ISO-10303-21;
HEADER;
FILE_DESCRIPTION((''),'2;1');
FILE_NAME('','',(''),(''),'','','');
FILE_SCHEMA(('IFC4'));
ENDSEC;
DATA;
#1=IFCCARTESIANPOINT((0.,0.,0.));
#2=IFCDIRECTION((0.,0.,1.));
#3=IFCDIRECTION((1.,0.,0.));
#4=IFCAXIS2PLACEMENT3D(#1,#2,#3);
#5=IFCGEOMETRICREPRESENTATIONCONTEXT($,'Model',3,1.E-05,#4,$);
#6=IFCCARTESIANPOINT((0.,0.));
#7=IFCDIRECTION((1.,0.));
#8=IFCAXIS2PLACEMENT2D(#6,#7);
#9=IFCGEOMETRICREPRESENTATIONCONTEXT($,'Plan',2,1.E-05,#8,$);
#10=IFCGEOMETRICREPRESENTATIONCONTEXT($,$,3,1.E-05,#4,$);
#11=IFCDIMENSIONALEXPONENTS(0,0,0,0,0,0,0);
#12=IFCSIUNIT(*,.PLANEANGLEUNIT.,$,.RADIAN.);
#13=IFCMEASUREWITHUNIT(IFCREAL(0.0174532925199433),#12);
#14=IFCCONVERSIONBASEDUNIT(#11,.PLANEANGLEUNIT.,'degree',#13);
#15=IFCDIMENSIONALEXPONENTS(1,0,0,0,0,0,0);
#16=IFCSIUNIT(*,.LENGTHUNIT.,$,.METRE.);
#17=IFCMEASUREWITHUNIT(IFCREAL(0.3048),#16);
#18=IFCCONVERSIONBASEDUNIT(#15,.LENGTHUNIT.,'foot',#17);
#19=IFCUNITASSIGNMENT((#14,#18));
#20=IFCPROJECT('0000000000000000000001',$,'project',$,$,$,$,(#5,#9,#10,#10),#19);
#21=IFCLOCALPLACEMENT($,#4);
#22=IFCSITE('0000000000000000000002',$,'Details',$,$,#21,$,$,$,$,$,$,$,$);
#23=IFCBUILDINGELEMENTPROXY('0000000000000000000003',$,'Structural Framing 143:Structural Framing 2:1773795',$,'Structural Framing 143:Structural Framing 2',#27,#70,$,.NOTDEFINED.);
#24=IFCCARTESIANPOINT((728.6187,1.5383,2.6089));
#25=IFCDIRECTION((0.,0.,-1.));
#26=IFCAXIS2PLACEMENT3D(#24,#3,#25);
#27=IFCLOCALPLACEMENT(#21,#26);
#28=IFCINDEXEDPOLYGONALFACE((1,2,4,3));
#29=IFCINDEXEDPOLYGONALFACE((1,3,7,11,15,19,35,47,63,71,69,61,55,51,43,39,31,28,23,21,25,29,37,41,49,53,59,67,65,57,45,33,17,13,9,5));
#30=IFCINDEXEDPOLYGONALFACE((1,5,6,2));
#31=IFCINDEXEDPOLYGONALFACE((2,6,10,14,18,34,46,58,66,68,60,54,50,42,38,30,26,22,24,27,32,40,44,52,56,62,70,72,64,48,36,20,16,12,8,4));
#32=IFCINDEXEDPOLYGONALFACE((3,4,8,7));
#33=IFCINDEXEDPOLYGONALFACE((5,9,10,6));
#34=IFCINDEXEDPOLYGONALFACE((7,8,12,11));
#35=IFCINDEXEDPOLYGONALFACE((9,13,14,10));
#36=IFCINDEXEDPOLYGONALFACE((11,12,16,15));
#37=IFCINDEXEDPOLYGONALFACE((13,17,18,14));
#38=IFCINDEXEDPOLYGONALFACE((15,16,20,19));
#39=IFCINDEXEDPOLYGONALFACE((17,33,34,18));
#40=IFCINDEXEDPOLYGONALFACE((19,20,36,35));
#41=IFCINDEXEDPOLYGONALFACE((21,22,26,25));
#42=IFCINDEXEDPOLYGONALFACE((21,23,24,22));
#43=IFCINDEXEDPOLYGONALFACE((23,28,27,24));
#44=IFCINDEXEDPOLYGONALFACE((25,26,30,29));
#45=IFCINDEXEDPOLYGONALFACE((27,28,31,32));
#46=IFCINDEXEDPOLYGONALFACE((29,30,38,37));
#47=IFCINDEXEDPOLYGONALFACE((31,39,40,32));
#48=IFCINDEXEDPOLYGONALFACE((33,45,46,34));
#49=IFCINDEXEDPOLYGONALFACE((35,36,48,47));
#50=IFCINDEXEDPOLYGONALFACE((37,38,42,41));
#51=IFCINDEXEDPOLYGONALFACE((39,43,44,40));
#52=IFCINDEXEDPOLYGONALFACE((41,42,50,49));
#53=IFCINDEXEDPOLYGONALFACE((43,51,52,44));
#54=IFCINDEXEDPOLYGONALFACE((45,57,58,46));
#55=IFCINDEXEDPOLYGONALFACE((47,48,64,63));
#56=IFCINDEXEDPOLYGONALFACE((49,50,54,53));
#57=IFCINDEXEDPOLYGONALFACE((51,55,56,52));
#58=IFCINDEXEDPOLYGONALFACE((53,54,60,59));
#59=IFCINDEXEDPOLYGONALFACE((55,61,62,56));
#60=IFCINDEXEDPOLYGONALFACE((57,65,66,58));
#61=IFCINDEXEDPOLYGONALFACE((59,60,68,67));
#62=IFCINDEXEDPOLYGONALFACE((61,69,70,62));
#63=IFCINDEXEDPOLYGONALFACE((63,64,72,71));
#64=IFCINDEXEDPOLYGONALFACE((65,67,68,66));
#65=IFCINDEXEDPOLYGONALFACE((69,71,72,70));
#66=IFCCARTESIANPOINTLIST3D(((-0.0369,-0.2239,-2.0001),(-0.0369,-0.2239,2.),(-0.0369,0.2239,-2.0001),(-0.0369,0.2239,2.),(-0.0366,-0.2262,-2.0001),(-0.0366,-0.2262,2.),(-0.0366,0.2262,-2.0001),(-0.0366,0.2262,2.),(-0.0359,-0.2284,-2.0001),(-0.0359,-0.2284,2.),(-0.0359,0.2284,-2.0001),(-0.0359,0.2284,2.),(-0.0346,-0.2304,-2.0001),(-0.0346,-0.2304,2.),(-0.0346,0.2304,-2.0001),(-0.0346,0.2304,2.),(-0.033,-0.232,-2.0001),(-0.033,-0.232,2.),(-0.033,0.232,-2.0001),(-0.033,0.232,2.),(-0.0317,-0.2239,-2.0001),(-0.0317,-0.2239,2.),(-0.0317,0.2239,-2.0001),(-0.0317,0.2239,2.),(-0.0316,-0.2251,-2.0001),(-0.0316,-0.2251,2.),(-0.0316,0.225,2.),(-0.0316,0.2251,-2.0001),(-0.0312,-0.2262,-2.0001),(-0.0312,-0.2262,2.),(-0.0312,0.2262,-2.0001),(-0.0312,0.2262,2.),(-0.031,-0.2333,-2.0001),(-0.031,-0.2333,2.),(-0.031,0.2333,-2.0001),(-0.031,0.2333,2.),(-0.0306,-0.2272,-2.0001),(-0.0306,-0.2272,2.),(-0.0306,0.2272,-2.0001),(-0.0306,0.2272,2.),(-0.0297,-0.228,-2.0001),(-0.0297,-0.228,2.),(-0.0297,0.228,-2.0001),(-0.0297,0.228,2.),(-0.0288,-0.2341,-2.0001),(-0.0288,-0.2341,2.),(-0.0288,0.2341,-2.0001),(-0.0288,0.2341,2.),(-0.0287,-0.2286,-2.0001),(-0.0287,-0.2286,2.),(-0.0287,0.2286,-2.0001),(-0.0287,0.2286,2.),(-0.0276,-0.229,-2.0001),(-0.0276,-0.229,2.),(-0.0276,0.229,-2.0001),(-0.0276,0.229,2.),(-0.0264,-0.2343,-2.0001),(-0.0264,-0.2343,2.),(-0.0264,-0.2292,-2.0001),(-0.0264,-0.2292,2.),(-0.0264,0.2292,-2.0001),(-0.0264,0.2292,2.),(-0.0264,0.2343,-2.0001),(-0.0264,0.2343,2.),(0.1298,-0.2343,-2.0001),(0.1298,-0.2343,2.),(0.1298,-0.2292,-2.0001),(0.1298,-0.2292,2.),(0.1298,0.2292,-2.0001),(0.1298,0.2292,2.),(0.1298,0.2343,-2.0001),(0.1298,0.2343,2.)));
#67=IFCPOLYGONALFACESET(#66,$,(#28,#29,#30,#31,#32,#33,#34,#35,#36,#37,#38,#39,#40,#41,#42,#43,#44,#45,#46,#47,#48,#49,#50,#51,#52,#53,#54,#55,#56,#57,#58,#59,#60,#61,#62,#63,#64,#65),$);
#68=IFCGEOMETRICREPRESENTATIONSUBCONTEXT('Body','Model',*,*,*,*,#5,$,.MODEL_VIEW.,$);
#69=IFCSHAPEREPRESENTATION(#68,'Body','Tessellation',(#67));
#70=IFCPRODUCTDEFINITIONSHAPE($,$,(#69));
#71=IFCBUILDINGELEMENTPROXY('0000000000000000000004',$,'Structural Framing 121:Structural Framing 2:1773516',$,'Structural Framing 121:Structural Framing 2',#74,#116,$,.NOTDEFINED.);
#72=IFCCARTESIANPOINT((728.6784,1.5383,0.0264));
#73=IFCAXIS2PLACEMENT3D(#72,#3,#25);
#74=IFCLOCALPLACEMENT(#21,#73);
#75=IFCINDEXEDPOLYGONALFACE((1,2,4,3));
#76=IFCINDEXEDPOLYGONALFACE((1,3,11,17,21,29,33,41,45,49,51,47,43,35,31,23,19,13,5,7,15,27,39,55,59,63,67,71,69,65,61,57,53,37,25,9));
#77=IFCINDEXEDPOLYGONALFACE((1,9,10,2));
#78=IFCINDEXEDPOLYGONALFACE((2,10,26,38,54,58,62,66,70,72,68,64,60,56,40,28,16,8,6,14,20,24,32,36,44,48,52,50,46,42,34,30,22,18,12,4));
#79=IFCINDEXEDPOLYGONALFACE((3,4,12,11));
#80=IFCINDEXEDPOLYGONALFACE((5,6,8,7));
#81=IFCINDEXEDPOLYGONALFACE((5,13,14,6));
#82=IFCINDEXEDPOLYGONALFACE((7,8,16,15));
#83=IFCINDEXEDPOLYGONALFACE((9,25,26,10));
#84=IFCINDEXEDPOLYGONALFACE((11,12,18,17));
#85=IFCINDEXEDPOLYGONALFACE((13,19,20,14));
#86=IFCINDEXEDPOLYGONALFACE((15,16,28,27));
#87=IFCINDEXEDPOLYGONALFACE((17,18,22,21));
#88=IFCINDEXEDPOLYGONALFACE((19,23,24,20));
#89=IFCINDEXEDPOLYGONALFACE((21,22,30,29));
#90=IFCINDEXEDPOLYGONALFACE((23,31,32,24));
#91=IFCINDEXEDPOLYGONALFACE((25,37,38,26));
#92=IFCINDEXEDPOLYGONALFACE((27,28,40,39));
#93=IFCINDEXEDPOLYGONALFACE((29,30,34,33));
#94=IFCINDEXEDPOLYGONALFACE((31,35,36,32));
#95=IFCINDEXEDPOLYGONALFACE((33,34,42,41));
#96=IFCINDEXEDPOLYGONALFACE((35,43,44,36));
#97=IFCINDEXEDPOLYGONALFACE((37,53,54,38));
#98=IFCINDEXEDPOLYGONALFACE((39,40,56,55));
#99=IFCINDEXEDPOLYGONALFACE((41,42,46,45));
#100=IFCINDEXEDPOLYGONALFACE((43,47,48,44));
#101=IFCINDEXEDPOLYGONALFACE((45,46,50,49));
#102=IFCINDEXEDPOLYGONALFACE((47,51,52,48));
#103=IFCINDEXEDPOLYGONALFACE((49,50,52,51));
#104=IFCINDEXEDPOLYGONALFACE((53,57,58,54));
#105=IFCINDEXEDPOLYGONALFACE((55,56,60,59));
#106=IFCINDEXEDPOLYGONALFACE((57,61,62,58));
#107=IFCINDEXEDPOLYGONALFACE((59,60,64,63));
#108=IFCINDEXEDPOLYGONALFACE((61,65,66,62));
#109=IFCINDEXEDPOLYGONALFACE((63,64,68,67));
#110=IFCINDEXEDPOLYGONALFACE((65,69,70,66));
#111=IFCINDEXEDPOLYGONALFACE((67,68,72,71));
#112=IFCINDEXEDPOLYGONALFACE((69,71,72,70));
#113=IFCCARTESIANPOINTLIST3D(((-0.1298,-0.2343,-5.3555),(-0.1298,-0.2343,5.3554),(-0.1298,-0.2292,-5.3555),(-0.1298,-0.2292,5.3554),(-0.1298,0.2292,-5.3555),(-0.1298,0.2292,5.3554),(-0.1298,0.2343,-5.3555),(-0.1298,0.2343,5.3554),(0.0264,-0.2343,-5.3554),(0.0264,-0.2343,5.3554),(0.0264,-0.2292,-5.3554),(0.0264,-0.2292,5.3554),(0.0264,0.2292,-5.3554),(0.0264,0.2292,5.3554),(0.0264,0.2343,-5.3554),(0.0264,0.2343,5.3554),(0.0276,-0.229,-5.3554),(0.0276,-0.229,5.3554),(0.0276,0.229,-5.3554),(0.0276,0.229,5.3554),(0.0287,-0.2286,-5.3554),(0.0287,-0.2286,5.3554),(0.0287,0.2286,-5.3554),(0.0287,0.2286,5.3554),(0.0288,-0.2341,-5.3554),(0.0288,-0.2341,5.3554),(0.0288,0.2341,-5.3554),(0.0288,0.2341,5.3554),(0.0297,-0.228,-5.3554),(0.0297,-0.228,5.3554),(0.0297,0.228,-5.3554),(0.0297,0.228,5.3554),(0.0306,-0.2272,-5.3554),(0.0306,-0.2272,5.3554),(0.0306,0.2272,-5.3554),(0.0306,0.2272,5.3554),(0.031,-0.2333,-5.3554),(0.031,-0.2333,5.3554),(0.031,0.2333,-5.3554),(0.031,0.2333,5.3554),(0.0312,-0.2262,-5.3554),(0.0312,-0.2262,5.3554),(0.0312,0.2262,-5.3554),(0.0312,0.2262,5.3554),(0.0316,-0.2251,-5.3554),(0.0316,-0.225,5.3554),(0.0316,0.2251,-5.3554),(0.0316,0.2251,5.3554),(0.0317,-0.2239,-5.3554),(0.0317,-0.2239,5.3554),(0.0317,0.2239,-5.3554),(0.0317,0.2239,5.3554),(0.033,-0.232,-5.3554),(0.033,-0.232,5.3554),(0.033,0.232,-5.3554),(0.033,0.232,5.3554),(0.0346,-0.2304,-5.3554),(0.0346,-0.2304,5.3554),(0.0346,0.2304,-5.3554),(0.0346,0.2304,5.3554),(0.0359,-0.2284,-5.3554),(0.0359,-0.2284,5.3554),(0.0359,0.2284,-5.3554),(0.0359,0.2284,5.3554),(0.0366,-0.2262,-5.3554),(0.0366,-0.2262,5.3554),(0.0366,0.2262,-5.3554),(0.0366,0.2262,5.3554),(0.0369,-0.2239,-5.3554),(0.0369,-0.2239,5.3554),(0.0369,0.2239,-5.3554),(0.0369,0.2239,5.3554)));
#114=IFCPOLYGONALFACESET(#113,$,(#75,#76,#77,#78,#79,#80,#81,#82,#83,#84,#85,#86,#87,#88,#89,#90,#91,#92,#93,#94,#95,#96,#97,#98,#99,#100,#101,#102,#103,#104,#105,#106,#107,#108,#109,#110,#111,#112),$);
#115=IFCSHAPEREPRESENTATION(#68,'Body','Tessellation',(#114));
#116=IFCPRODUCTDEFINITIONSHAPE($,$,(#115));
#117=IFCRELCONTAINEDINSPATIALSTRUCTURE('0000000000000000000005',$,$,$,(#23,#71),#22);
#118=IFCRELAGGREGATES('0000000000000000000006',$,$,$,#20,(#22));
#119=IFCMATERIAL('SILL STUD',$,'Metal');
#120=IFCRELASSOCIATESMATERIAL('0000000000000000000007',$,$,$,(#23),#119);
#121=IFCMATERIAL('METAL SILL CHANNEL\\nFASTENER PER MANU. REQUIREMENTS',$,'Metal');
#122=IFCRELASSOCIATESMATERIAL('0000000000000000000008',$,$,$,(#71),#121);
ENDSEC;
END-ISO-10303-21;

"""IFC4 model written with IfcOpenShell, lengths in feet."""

from ifc_helpers import new_model, entity, si_unit, converted_unit, frame, origin_with_axes, origin_2d_with_axis, place, context, subcontext, project, spatial, polyline, outline, extrude, material, element, save


model = new_model("IFC4")

# Units and contexts
model_context = context("Model", 3, precision=1e-05, world=origin_with_axes())
plan_context = context("Plan", 2, precision=1e-05, world=origin_2d_with_axis())
context_of_model = context(None, 3, precision=1e-05, world=origin_with_axes())
body_context = subcontext(model_context, "Body", "Model", "MODEL_VIEW")
ifc_project = project(units=[converted_unit("PLANEANGLEUNIT", "degree", entity("IfcReal", 0.0174532925199433), si_unit("PLANEANGLEUNIT", "RADIAN"), dimensions=[0, 0, 0, 0, 0, 0, 0]), converted_unit("LENGTHUNIT", "foot", entity("IfcReal", 0.3048), si_unit("LENGTHUNIT", "METRE"), dimensions=[1, 0, 0, 0, 0, 0, 0])], contexts=[model_context, plan_context, context_of_model, context_of_model])

# Site
site_placement = place(None, origin_with_axes())
site = spatial("IfcSite", under=ifc_project, at=site_placement, Name="Details")

# Building element proxies
ifc_material_1 = material(Name="SILL STUD", Category="Metal")
proxy_1_placement = place(site_placement, frame((728.6187, 1.5383, 2.6089), z_axis=(1.0, 0.0, 0.0), x_axis=(0.0, 0.0, -1.0)))
element("IfcBuildingElementProxy", 1, at=proxy_1_placement, inside=site, material=ifc_material_1, Name="Structural Framing 143:Structural Framing 2:1773795", ObjectType="Structural Framing 143:Structural Framing 2", PredefinedType="NOTDEFINED", context=body_context, shape_type="SweptSolid", body=[
    extrude(outline(polyline([(0.2295, 0.0), (0.2295, -0.0012), (0.2199, -0.1571), (0.225, -0.1574), (0.2347, -0.0015), (0.2346, 0.0008), (0.2339, 0.0031), (0.2328, 0.0051), (0.2313, 0.0069), (0.2294, 0.0083), (0.2272, 0.0092), (0.2249, 0.0096), (-0.222, 0.0373), (-0.2243, 0.0372), (-0.2266, 0.0366), (-0.2286, 0.0354), (-0.2304, 0.0339), (-0.2317, 0.032), (-0.2327, 0.0298), (-0.2331, 0.0275), (-0.2427, -0.1284), (-0.2376, -0.1287), (-0.2279, 0.0272), (-0.2277, 0.0284), (-0.2273, 0.0295), (-0.2266, 0.0304), (-0.2257, 0.0312), (-0.2246, 0.0318), (-0.2235, 0.0321), (-0.2223, 0.0322), (0.2246, 0.0044), (0.2257, 0.0042), (0.2268, 0.0038), (0.2278, 0.0031), (0.2286, 0.0022), (0.2292, 0.0011), (0.2295, 0.0)])), frame((-0.0134, 0.0, -2.0001), z_axis=(0.000047, 0.0, -1.0), x_axis=(-0.061956, -0.998079, -0.000003)), (-0.000003, -0.000047, -1.0), 4.0),
])
ifc_material_2 = material(Name="METAL SILL CHANNEL\\nFASTENER PER MANU. REQUIREMENTS", Category="Metal")
proxy_2_placement = place(site_placement, frame((728.6784, 1.5383, 0.0264), z_axis=(1.0, 0.0, 0.0), x_axis=(0.0, 0.0, -1.0)))
element("IfcBuildingElementProxy", 2, at=proxy_2_placement, inside=site, material=ifc_material_2, Name="Structural Framing 121:Structural Framing 2:1773516", ObjectType="Structural Framing 121:Structural Framing 2", PredefinedType="NOTDEFINED", context=body_context, shape_type="SweptSolid", body=[
    extrude(outline(polyline([(0.2295, 0.0), (0.2295, -0.0012), (0.2199, -0.1571), (0.225, -0.1574), (0.2347, -0.0015), (0.2346, 0.0008), (0.2339, 0.0031), (0.2328, 0.0051), (0.2313, 0.0069), (0.2294, 0.0083), (0.2272, 0.0092), (0.2249, 0.0096), (-0.222, 0.0373), (-0.2243, 0.0372), (-0.2266, 0.0366), (-0.2286, 0.0354), (-0.2304, 0.0339), (-0.2317, 0.032), (-0.2327, 0.0298), (-0.2331, 0.0275), (-0.2427, -0.1284), (-0.2376, -0.1287), (-0.2279, 0.0272), (-0.2277, 0.0284), (-0.2273, 0.0295), (-0.2266, 0.0304), (-0.2257, 0.0312), (-0.2246, 0.0318), (-0.2235, 0.0321), (-0.2223, 0.0322), (0.2246, 0.0044), (0.2257, 0.0042), (0.2268, 0.0038), (0.2278, 0.0031), (0.2286, 0.0022), (0.2292, 0.0011), (0.2295, 0.0)])), frame((0.0134, 0.0, -5.3554), z_axis=(0.000074, 0.0, -1.0), x_axis=(0.061956, 0.998079, 0.000005)), (0.000005, 0.000074, -1.0), 10.7109),
])

save(model, "model.ifc")
